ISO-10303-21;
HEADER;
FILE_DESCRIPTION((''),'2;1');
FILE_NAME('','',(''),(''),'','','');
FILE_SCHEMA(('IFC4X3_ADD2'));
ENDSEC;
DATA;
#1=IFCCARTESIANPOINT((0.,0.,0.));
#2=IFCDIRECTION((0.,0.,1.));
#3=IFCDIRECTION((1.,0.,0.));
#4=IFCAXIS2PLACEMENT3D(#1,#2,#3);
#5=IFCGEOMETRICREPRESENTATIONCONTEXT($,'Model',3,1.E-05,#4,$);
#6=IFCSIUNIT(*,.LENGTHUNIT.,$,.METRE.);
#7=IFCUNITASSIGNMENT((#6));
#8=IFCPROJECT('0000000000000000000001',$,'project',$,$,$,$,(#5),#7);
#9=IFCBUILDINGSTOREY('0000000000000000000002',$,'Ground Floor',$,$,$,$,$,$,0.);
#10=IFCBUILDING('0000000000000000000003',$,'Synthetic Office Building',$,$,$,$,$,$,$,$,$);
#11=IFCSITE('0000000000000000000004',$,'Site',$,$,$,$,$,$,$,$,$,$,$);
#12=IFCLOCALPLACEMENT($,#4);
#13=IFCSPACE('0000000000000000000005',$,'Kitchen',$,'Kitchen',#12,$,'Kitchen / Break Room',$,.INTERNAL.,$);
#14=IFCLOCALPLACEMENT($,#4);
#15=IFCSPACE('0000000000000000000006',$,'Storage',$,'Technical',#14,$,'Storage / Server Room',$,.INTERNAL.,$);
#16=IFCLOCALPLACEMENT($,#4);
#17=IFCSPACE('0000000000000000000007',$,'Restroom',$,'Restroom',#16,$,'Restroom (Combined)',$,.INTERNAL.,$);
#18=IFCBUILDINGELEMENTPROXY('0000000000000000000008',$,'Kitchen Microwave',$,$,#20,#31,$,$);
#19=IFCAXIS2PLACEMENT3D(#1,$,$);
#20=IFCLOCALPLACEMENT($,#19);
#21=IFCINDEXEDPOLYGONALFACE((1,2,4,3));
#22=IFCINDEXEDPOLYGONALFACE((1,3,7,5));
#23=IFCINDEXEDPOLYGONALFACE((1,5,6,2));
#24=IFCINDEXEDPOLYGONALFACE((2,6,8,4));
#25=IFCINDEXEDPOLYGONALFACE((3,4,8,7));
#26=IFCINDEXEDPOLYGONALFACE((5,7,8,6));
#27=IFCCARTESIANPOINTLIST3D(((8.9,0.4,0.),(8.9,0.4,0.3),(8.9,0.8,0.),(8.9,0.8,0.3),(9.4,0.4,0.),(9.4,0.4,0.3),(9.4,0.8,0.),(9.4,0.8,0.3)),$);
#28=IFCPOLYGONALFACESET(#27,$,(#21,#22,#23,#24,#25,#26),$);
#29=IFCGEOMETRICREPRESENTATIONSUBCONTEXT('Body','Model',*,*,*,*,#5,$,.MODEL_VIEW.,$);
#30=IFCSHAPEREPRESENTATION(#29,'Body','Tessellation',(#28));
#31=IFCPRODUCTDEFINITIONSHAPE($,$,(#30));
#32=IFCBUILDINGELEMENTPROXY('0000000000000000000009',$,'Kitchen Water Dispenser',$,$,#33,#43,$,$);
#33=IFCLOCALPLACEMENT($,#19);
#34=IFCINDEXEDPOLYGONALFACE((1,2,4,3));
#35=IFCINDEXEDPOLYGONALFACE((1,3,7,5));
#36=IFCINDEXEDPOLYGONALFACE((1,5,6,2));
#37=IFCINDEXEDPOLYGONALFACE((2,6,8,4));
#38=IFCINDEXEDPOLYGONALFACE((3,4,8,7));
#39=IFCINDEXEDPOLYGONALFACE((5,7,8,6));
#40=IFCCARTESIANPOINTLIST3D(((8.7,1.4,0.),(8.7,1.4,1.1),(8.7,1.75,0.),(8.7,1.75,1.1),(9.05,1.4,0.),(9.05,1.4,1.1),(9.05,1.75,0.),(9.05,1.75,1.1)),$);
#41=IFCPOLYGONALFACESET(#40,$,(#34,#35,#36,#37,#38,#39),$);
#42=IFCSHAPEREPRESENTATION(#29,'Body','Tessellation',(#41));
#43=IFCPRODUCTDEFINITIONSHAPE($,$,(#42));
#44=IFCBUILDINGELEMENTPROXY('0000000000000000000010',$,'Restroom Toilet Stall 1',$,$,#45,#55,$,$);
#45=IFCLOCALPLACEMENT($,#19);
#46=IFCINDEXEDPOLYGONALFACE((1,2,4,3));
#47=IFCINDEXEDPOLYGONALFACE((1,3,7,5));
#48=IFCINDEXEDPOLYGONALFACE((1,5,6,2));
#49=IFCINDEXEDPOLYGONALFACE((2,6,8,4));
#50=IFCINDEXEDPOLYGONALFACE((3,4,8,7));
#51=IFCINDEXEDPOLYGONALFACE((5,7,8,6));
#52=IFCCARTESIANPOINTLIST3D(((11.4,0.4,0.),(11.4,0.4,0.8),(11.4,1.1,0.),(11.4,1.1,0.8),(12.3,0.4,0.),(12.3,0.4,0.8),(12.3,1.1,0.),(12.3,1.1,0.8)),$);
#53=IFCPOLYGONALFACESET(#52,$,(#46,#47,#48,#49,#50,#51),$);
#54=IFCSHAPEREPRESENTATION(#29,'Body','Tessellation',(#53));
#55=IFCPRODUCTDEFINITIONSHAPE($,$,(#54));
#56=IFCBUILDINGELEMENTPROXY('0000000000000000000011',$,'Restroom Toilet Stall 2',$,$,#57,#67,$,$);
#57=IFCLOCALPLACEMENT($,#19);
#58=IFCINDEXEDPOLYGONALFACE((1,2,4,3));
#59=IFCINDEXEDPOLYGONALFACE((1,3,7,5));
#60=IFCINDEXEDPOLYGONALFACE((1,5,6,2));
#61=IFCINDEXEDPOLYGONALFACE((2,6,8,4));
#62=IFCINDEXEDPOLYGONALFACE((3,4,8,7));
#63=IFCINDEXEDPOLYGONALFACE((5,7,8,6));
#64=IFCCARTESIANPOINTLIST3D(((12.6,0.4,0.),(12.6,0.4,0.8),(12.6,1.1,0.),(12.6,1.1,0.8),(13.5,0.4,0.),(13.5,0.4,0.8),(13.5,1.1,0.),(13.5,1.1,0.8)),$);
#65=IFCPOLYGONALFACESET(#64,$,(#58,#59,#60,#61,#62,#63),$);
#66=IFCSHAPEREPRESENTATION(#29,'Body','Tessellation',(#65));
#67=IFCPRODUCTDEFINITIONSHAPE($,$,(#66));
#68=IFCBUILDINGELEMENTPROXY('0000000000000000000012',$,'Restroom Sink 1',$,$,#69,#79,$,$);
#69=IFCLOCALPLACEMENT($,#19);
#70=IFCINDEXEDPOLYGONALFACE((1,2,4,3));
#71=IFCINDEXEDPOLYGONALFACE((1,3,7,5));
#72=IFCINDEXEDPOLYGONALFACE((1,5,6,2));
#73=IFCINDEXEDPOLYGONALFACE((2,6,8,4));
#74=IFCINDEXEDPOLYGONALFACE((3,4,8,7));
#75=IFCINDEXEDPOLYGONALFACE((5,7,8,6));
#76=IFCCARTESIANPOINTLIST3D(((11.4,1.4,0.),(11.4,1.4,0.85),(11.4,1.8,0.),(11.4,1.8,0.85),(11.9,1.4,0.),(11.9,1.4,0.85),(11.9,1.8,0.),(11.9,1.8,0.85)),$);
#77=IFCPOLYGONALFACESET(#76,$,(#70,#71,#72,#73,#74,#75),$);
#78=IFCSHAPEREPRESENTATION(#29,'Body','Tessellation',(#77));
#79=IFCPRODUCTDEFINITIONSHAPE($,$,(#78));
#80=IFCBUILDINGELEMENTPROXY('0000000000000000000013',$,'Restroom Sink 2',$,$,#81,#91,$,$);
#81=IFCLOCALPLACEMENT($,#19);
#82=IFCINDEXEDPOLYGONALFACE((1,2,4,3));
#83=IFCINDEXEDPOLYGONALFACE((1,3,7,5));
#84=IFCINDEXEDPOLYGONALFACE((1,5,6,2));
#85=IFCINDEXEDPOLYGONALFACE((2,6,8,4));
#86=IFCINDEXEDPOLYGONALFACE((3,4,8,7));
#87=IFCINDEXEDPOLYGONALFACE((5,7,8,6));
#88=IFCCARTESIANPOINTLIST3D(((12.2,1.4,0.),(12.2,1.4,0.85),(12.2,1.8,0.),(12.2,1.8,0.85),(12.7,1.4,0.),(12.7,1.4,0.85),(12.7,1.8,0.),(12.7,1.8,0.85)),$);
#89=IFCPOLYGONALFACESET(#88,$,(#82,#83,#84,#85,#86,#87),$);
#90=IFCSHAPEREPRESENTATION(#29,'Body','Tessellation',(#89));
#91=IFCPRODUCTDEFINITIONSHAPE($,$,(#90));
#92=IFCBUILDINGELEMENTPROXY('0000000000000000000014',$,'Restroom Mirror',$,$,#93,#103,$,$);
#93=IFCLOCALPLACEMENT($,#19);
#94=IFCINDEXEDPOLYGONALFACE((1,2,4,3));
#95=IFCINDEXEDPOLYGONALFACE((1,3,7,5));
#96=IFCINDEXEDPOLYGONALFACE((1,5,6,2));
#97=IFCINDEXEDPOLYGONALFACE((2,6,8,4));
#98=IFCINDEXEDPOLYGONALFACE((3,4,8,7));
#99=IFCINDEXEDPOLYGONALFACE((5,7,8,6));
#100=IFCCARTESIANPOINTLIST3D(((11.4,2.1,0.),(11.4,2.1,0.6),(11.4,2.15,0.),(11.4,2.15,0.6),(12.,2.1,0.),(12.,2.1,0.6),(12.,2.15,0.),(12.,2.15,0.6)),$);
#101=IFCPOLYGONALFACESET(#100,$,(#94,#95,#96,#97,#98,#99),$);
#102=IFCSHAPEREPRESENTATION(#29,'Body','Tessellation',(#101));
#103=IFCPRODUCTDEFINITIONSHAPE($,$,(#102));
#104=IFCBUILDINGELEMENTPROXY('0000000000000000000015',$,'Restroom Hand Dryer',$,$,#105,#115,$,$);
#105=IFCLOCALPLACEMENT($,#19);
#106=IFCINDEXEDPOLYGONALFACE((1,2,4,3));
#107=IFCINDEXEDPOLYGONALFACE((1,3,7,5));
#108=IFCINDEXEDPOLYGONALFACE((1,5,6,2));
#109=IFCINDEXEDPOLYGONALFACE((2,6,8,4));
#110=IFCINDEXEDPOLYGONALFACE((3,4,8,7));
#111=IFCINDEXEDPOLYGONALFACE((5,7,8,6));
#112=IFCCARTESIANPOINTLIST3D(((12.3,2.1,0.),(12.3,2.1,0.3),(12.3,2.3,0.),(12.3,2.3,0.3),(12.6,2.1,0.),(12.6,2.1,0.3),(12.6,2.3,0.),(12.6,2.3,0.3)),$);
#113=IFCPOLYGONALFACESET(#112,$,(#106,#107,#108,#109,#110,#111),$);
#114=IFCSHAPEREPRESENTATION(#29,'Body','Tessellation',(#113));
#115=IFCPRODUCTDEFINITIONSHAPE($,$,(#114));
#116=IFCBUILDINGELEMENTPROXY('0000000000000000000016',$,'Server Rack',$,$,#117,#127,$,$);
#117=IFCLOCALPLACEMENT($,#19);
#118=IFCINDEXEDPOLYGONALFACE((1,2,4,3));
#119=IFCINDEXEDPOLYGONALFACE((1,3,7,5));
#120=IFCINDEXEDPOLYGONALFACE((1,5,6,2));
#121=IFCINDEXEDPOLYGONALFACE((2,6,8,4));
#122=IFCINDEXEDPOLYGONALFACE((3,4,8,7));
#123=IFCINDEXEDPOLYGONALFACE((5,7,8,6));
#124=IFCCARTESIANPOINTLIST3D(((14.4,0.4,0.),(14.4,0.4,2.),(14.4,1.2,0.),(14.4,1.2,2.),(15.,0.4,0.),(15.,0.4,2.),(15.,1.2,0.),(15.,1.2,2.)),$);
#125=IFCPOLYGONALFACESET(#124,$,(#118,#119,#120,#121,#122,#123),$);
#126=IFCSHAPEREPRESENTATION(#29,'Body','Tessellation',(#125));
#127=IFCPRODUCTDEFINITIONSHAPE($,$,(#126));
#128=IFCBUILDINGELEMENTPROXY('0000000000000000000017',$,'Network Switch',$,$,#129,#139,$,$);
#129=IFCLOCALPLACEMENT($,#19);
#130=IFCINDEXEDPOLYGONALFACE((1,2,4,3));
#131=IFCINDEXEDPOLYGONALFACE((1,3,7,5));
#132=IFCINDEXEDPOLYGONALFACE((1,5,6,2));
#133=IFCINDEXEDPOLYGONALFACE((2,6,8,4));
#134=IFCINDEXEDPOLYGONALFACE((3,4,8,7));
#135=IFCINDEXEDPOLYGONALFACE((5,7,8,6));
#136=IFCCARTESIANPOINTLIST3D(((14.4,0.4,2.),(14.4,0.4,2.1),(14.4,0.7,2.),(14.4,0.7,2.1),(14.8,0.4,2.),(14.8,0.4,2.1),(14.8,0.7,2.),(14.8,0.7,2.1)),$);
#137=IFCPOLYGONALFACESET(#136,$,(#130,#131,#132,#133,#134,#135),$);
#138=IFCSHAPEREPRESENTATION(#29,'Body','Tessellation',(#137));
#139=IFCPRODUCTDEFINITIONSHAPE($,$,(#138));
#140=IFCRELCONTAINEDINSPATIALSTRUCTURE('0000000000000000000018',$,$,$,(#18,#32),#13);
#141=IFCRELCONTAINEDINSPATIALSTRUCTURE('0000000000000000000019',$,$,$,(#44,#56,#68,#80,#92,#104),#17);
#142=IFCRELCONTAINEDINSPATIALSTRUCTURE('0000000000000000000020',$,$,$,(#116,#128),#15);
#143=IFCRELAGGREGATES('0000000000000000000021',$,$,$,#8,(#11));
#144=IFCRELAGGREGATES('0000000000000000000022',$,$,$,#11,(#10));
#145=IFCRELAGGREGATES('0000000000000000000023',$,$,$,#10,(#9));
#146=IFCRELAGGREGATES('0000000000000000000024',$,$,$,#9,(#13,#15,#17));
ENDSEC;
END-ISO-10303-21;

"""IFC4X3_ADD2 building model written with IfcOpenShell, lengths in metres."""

from ifc_helpers import new_model, si_unit, frame, origin_with_axes, place, context, subcontext, project, spatial, polyline, outline, extrude, element, save


model = new_model("IFC4X3_ADD2")

# Units and contexts
model_context = context("Model", 3, precision=1e-05, world=origin_with_axes())
body_context = subcontext(model_context, "Body", "Model", "MODEL_VIEW")
ifc_project = project(units=[si_unit("LENGTHUNIT", "METRE")], contexts=[model_context])

# Site, building, storey
site = spatial("IfcSite", under=ifc_project, Name="Site")
building = spatial("IfcBuilding", under=site, Name="Synthetic Office Building")
storey = spatial("IfcBuildingStorey", under=building, Name="Ground Floor", Elevation=0.0)

# Shared definitions
space_1_placement = place(None, origin_with_axes())
space_1 = spatial("IfcSpace", under=storey, at=space_1_placement, Name="Kitchen", ObjectType="Kitchen", LongName="Kitchen / Break Room", PredefinedType="INTERNAL")

# Shared definitions
space_2_placement = place(None, origin_with_axes())
space_2 = spatial("IfcSpace", under=storey, at=space_2_placement, Name="Storage", ObjectType="Technical", LongName="Storage / Server Room", PredefinedType="INTERNAL")

# Building element proxies
proxy_1_placement = place(space_1_placement, origin_with_axes())
element("IfcBuildingElementProxy", 1, at=proxy_1_placement, inside=space_1, Name="Kitchen Microwave", context=body_context, shape_type="SweptSolid", body=[
    extrude(outline(polyline([(8.9, 0.4), (9.4, 0.4), (9.4, 0.8), (8.9, 0.8), (8.9, 0.4)])), origin_with_axes(), (0.0, 0.0, 1.0), 0.3),
])
proxy_2_placement = place(space_1_placement, origin_with_axes())
element("IfcBuildingElementProxy", 2, at=proxy_2_placement, inside=space_1, Name="Kitchen Water Dispenser", context=body_context, shape_type="SweptSolid", body=[
    extrude(outline(polyline([(8.7, 1.4), (9.05, 1.4), (9.05, 1.75), (8.7, 1.75), (8.7, 1.4)])), origin_with_axes(), (0.0, 0.0, 1.0), 1.1),
])

# Shared definitions
space_3_placement = place(None, origin_with_axes())
space_3 = spatial("IfcSpace", under=storey, at=space_3_placement, Name="Restroom", ObjectType="Restroom", LongName="Restroom (Combined)", PredefinedType="INTERNAL")

# Building element proxies
proxy_3_placement = place(space_3_placement, origin_with_axes())
element("IfcBuildingElementProxy", 3, at=proxy_3_placement, inside=space_3, Name="Restroom Toilet Stall 1", context=body_context, shape_type="SweptSolid", body=[
    extrude(outline(polyline([(11.4, 0.4), (12.3, 0.4), (12.3, 1.1), (11.4, 1.1), (11.4, 0.4)])), origin_with_axes(), (0.0, 0.0, 1.0), 0.8),
])
proxy_4_placement = place(space_3_placement, origin_with_axes())
element("IfcBuildingElementProxy", 4, at=proxy_4_placement, inside=space_3, Name="Restroom Toilet Stall 2", context=body_context, shape_type="SweptSolid", body=[
    extrude(outline(polyline([(12.6, 0.4), (13.5, 0.4), (13.5, 1.1), (12.6, 1.1), (12.6, 0.4)])), origin_with_axes(), (0.0, 0.0, 1.0), 0.8),
])
proxy_5_placement = place(space_3_placement, origin_with_axes())
element("IfcBuildingElementProxy", 5, at=proxy_5_placement, inside=space_3, Name="Restroom Sink 1", context=body_context, shape_type="SweptSolid", body=[
    extrude(outline(polyline([(11.4, 1.4), (11.9, 1.4), (11.9, 1.8), (11.4, 1.8), (11.4, 1.4)])), origin_with_axes(), (0.0, 0.0, 1.0), 0.85),
])
proxy_6_placement = place(space_3_placement, origin_with_axes())
element("IfcBuildingElementProxy", 6, at=proxy_6_placement, inside=space_3, Name="Restroom Sink 2", context=body_context, shape_type="SweptSolid", body=[
    extrude(outline(polyline([(12.2, 1.4), (12.7, 1.4), (12.7, 1.8), (12.2, 1.8), (12.2, 1.4)])), origin_with_axes(), (0.0, 0.0, 1.0), 0.85),
])
proxy_7_placement = place(space_3_placement, origin_with_axes())
element("IfcBuildingElementProxy", 7, at=proxy_7_placement, inside=space_3, Name="Restroom Mirror", context=body_context, shape_type="SweptSolid", body=[
    extrude(outline(polyline([(11.4, 2.1), (12.0, 2.1), (12.0, 2.15), (11.4, 2.15), (11.4, 2.1)])), origin_with_axes(), (0.0, 0.0, 1.0), 0.6),
])
proxy_8_placement = place(space_3_placement, origin_with_axes())
element("IfcBuildingElementProxy", 8, at=proxy_8_placement, inside=space_3, Name="Restroom Hand Dryer", context=body_context, shape_type="SweptSolid", body=[
    extrude(outline(polyline([(12.3, 2.1), (12.6, 2.1), (12.6, 2.3), (12.3, 2.3), (12.3, 2.1)])), origin_with_axes(), (0.0, 0.0, 1.0), 0.3),
])
proxy_9_placement = place(space_2_placement, origin_with_axes())
element("IfcBuildingElementProxy", 9, at=proxy_9_placement, inside=space_2, Name="Server Rack", context=body_context, shape_type="SweptSolid", body=[
    extrude(outline(polyline([(14.4, 0.4), (15.0, 0.4), (15.0, 1.2), (14.4, 1.2), (14.4, 0.4)])), origin_with_axes(), (0.0, 0.0, 1.0), 2.0),
])
proxy_10_placement = place(space_2_placement, origin_with_axes())
element("IfcBuildingElementProxy", 10, at=proxy_10_placement, inside=space_2, Name="Network Switch", context=body_context, shape_type="SweptSolid", body=[
    extrude(outline(polyline([(14.4, 0.4), (14.8, 0.4), (14.8, 0.7), (14.4, 0.7), (14.4, 0.4)])), frame((0.0, 0.0, 2.0), z_axis=(0.0, 0.0, 1.0), x_axis=(1.0, 0.0, 0.0)), (0.0, 0.0, 1.0), 0.1),
])

save(model, "model.ifc")
